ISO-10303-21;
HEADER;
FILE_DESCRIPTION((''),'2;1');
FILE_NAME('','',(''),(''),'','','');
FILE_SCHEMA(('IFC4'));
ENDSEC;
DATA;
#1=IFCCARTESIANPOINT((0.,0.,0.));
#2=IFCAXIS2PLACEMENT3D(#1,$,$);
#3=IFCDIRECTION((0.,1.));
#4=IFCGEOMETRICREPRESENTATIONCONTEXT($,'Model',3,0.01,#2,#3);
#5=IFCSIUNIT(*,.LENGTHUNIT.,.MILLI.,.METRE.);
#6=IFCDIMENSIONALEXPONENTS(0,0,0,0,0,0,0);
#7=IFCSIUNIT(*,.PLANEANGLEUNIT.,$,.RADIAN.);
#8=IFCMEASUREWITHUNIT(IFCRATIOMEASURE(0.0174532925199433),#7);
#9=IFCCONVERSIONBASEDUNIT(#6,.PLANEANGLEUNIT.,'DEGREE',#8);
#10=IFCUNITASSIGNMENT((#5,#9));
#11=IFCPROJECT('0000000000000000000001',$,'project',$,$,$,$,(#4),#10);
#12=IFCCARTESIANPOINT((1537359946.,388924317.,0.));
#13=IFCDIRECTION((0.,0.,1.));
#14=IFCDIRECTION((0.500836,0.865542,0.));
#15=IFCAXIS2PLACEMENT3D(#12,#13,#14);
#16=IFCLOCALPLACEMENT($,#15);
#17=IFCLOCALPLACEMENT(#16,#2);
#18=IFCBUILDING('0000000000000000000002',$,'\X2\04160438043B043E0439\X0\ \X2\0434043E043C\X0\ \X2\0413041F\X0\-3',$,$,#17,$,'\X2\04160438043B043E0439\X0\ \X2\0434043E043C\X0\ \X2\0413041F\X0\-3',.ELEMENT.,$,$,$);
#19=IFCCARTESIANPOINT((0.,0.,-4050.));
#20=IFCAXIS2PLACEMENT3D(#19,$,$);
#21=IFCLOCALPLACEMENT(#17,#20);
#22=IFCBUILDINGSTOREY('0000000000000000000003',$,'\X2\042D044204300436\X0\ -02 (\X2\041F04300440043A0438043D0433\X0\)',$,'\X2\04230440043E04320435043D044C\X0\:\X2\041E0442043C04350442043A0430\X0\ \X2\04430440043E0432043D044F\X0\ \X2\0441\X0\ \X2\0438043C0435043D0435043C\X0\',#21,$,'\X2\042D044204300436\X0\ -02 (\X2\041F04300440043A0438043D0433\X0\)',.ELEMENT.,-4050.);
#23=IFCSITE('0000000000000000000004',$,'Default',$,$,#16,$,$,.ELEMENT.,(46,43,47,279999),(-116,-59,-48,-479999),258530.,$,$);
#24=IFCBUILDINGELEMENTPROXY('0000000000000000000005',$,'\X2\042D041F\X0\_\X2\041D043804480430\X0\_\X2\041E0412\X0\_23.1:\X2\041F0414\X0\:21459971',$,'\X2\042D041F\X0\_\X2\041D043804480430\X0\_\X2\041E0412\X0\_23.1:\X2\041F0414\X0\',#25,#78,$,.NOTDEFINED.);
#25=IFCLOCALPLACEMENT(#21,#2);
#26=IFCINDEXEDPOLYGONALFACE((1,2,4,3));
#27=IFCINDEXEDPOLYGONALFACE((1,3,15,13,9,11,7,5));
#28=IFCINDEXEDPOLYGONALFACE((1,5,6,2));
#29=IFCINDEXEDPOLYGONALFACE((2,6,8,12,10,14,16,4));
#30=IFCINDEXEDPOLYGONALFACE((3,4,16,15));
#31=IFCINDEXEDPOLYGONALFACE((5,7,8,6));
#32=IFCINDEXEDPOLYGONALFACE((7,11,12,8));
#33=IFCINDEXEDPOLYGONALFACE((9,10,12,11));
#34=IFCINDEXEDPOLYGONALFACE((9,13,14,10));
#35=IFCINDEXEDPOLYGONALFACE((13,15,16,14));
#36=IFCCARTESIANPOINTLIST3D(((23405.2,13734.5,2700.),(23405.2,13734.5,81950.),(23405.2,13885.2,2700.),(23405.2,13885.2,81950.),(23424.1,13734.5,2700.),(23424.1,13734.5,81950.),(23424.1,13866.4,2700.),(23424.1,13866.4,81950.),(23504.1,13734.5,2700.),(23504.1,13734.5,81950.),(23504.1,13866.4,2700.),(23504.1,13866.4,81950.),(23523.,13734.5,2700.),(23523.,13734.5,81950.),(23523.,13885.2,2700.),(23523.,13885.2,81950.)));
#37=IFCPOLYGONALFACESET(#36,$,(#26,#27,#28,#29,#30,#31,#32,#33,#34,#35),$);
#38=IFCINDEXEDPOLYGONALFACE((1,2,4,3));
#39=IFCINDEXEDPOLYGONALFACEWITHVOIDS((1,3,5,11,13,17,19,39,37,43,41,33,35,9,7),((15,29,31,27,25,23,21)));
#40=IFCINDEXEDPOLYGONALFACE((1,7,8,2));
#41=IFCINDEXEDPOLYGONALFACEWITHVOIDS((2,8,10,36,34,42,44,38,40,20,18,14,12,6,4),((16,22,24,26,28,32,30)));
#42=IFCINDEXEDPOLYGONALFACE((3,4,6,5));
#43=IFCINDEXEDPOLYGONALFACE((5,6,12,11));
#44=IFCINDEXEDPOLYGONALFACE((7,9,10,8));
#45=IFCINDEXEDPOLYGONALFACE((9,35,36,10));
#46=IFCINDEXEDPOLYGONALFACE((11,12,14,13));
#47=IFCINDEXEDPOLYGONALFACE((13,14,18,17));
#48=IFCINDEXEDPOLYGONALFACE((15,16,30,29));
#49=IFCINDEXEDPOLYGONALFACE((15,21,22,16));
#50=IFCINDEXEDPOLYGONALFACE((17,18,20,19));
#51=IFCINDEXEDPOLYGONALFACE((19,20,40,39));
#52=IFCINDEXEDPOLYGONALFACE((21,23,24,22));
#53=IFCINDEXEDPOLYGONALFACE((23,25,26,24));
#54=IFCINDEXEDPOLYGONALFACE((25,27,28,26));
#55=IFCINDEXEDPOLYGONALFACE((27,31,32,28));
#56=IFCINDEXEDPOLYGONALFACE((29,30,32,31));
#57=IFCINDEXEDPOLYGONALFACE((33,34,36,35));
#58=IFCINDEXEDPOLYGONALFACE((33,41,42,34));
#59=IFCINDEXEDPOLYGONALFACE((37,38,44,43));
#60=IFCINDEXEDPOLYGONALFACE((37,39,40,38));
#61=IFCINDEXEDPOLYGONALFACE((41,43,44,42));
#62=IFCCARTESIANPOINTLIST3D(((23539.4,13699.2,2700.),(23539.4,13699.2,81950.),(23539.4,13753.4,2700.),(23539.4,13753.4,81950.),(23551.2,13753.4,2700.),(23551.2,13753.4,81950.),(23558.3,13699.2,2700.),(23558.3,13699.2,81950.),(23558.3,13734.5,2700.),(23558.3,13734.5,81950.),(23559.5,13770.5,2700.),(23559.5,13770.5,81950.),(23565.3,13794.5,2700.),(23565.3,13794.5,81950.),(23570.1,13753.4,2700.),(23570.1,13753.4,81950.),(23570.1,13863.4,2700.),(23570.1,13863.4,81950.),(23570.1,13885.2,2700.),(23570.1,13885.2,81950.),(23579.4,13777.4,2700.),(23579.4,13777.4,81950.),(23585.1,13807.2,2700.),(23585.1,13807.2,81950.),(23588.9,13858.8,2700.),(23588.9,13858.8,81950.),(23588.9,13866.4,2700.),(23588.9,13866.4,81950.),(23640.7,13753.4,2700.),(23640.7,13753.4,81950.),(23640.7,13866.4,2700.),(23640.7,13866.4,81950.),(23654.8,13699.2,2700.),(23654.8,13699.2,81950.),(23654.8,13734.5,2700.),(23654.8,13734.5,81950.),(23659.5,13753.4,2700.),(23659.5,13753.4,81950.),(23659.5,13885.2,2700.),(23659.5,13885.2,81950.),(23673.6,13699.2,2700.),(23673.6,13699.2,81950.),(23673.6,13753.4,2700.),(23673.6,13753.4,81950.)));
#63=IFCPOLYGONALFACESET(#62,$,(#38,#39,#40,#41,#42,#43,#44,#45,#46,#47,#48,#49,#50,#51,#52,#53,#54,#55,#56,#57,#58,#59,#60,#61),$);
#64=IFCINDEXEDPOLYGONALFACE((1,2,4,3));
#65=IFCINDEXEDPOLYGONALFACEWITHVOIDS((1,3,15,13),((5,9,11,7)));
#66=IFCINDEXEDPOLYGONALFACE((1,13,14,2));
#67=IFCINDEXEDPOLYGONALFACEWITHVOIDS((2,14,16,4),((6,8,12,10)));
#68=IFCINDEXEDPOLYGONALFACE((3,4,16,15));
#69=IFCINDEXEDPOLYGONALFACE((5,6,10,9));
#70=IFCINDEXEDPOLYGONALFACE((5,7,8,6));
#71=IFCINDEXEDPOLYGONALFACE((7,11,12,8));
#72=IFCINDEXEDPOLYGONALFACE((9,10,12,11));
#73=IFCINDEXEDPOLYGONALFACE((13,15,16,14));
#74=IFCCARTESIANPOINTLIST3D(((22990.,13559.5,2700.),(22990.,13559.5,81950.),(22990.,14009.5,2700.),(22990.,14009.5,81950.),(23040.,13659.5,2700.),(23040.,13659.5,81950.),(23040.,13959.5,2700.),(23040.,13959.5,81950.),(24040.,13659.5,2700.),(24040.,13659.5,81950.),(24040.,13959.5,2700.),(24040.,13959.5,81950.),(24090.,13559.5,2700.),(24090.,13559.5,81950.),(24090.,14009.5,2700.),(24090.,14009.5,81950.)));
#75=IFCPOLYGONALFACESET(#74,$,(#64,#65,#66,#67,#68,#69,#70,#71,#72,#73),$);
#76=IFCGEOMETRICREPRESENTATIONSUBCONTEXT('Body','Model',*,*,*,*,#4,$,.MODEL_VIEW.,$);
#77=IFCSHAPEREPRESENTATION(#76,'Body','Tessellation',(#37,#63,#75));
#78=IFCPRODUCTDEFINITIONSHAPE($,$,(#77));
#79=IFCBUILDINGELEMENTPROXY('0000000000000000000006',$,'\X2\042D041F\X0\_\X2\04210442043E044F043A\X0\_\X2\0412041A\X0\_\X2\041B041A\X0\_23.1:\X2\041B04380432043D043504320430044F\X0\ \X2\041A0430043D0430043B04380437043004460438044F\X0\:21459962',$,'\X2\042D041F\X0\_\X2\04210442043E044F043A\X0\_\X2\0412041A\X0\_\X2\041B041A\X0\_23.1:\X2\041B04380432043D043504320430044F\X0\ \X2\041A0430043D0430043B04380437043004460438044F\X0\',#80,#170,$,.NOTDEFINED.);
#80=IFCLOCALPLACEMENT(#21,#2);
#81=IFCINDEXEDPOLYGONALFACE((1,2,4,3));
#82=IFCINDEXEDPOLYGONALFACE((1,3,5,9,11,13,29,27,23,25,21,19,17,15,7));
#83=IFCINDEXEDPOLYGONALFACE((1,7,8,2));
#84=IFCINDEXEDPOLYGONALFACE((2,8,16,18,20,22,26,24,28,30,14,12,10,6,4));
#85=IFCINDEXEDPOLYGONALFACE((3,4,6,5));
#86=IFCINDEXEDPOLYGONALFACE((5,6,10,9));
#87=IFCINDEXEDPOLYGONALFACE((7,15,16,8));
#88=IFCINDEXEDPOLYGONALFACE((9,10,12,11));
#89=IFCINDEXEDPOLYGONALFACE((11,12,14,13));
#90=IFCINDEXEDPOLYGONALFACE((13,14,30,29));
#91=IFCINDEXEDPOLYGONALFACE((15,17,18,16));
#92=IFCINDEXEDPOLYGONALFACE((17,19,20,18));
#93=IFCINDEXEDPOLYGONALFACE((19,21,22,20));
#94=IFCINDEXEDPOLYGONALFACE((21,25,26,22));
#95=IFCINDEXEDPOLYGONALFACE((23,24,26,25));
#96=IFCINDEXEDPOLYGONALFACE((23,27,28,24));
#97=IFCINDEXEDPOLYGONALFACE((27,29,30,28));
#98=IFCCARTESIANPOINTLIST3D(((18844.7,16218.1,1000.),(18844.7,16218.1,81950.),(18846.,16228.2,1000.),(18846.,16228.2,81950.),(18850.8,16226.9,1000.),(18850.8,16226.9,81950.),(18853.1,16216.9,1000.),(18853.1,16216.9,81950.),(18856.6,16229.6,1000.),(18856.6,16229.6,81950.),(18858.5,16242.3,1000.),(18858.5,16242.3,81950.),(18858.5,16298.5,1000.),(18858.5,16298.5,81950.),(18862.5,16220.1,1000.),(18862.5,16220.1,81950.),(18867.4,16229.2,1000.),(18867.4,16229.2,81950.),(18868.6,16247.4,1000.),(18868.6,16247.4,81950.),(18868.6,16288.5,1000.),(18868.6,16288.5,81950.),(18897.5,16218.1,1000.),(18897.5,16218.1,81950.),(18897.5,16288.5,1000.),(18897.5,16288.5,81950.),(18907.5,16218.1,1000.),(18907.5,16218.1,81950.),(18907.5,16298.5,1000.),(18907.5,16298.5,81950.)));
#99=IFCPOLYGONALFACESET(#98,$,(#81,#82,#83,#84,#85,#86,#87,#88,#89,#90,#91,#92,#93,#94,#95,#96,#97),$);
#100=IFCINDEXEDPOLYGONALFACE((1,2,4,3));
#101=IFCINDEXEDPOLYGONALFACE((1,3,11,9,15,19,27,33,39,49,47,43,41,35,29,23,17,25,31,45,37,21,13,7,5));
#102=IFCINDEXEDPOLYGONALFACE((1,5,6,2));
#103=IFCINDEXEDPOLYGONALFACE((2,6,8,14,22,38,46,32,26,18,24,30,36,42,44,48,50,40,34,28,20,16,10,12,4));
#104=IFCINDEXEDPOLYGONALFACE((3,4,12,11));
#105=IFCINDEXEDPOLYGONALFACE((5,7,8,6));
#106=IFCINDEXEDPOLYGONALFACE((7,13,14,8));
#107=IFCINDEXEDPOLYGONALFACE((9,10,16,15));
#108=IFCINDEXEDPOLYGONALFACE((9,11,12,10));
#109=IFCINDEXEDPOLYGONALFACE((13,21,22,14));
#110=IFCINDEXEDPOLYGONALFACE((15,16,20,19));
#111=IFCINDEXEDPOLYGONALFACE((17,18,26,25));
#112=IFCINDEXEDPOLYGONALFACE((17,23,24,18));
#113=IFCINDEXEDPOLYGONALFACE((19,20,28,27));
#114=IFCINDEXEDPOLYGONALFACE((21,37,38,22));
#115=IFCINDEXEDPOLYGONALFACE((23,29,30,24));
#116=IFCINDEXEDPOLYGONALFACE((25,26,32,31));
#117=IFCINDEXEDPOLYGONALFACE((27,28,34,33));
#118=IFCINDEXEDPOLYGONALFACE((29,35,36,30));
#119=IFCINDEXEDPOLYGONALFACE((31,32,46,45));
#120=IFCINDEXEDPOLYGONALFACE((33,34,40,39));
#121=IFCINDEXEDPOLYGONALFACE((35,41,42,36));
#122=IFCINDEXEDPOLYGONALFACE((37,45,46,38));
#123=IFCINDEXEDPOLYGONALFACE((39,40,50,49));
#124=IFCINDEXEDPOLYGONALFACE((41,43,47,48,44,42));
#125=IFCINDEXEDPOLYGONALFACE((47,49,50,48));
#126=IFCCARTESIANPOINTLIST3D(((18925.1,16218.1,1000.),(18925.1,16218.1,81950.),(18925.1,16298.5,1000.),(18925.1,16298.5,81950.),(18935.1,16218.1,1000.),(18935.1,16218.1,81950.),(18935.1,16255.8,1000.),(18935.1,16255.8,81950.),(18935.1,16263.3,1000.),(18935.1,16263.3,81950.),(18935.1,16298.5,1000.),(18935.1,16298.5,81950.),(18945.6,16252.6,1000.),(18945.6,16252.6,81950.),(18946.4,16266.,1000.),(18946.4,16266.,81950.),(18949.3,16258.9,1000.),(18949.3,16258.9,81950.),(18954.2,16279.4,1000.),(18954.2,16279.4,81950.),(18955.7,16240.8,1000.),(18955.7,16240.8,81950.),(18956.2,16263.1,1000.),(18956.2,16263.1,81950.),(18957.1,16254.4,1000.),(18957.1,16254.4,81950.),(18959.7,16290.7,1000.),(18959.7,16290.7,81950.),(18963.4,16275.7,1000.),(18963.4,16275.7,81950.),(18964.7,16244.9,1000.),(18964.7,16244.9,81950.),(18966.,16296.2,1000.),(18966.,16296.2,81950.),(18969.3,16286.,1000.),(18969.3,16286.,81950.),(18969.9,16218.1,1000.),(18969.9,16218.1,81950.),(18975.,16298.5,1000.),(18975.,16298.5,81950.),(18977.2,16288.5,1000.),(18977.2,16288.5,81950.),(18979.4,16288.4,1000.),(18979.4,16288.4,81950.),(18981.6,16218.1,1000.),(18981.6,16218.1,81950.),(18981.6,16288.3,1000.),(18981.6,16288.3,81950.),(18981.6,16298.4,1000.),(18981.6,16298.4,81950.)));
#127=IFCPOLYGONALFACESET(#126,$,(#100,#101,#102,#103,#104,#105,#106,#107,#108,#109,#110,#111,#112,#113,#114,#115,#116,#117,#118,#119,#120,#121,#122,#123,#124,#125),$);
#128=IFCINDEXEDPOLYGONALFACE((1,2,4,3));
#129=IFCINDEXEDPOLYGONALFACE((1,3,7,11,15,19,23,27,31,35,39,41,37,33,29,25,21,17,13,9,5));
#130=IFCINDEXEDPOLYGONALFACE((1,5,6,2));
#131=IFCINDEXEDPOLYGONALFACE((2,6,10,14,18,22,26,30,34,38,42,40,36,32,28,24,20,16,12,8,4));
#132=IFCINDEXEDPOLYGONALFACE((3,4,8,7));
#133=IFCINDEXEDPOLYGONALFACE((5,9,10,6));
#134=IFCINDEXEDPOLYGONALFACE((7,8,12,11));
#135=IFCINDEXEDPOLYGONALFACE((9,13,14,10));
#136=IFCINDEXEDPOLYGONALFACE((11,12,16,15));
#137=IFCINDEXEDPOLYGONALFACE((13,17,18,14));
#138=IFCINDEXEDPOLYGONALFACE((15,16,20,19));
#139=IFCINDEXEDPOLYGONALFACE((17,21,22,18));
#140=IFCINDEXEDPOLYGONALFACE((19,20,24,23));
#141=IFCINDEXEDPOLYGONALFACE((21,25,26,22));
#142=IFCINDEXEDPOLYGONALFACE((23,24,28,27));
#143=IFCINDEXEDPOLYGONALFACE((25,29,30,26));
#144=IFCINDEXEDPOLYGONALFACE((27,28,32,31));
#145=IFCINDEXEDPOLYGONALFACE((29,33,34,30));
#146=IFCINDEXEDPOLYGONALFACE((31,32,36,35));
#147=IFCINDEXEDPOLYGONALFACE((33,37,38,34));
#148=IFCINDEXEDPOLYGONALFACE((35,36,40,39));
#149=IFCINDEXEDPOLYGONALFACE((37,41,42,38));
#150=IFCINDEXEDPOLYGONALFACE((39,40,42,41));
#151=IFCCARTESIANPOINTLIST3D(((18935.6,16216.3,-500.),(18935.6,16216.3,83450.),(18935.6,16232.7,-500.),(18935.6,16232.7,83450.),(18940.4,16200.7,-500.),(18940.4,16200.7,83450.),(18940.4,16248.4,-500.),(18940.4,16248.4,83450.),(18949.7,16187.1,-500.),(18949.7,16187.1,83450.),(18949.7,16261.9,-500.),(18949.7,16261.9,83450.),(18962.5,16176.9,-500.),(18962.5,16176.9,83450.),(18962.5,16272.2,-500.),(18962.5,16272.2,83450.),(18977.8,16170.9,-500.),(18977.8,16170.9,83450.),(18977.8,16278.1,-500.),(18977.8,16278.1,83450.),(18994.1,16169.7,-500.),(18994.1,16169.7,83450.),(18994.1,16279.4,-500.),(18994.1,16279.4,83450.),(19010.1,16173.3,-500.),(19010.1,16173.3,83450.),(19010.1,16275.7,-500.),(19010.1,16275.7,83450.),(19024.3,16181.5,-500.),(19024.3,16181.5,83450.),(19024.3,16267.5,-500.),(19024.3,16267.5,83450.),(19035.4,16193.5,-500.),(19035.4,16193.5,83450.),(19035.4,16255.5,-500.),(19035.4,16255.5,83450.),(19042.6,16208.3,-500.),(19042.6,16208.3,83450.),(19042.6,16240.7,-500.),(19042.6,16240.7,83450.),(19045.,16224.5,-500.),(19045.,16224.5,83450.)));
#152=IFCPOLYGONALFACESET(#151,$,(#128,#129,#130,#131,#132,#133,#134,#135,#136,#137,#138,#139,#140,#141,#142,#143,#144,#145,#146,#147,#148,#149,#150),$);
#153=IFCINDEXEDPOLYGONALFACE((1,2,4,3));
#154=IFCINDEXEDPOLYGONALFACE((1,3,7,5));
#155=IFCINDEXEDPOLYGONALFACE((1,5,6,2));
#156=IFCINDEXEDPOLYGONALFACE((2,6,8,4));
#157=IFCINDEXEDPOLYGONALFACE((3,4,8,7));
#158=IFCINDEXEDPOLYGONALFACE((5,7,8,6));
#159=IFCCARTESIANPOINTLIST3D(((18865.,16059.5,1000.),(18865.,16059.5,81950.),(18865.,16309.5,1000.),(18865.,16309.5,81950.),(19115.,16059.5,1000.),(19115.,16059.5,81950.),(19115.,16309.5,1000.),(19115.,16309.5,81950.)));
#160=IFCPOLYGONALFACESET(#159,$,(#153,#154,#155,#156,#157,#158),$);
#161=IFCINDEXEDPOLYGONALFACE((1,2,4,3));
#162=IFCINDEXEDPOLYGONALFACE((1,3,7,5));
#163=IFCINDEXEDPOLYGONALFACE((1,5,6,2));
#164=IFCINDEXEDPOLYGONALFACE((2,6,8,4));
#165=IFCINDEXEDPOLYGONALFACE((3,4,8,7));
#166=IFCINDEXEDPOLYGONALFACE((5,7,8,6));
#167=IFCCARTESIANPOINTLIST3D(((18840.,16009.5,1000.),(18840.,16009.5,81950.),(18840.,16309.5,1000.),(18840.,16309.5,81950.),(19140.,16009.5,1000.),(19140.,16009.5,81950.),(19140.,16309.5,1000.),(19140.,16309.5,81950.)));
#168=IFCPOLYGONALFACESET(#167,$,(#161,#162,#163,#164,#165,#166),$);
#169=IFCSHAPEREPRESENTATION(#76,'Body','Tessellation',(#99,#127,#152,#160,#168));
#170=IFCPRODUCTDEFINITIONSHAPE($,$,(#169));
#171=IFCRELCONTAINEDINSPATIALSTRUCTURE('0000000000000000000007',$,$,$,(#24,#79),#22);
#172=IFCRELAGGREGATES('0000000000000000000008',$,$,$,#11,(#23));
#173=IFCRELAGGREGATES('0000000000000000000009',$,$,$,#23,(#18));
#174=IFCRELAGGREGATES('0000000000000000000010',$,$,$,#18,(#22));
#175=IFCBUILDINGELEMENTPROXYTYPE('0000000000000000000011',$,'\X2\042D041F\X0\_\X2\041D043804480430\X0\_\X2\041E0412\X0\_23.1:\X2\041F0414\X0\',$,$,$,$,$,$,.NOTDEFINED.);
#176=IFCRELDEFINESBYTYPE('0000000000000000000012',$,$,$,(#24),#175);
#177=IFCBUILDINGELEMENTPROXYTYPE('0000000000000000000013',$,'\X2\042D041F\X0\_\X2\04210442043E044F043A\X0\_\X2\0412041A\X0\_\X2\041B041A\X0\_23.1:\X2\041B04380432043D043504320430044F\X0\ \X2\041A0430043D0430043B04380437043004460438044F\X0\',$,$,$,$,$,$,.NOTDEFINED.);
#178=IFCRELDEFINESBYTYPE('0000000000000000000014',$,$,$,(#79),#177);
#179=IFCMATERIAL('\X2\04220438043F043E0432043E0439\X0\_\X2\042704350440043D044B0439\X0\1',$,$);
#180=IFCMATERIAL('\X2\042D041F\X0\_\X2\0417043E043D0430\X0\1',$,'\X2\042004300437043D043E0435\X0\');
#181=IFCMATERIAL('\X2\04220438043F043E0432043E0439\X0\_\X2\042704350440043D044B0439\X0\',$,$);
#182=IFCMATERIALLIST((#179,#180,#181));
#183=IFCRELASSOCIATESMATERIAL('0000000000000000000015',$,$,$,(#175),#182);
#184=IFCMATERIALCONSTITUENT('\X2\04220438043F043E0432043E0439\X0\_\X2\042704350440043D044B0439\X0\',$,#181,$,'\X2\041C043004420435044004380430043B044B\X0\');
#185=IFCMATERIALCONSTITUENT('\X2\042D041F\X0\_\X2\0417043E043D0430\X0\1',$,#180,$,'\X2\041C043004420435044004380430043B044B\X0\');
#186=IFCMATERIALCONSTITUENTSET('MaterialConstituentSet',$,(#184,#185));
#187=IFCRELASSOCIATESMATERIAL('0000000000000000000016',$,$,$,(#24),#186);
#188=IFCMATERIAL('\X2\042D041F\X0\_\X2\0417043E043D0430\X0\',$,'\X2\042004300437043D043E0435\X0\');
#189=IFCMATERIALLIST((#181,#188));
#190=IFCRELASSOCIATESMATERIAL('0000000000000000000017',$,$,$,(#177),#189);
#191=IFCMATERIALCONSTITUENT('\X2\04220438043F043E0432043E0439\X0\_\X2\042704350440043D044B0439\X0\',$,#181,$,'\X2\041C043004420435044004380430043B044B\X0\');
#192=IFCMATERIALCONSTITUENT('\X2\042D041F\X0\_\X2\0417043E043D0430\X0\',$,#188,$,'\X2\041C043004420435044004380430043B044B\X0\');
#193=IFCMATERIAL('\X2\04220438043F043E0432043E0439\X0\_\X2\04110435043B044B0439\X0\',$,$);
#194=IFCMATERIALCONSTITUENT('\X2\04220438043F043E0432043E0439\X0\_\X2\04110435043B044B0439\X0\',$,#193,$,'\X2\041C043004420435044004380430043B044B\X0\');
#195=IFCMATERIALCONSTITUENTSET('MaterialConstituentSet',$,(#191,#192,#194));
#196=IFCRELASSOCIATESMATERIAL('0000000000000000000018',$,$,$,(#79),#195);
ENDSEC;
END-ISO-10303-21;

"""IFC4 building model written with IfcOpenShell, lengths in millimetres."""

from ifc_helpers import new_model, entity, si_unit, converted_unit, direction, frame, frame_2d, origin, place, context, subcontext, project, spatial, polyline, rectangle, circle, outline, extrude, source, transform, mapped, material, material_list, constituent, constituent_set, type_object, type_shapes, element, save


model = new_model("IFC4")

# Units and contexts
model_context = context("Model", 3, precision=0.01, world=origin(), true_north=direction((0.0, 1.0)))
body_context = subcontext(model_context, "Body", "Model", "MODEL_VIEW")
ifc_project = project(units=[si_unit("LENGTHUNIT", "METRE", prefix="MILLI"), converted_unit("PLANEANGLEUNIT", "DEGREE", entity("IfcRatioMeasure", 0.0174532925199433), si_unit("PLANEANGLEUNIT", "RADIAN"), dimensions=[0, 0, 0, 0, 0, 0, 0])], contexts=[model_context])

# Site, building, storey
site_placement = place(None, frame((1537359946.0, 388924317.0, 0.0), z_axis=(0.0, 0.0, 1.0), x_axis=(0.500836, 0.865542, 0.0)))
site = spatial("IfcSite", under=ifc_project, at=site_placement, Name="Default", CompositionType="ELEMENT", RefLatitude=(46, 43, 47, 279999), RefLongitude=(-116, -59, -48, -479999), RefElevation=258530.0)
building_placement = place(site_placement, origin())
building = spatial("IfcBuilding", under=site, at=building_placement, Name="Жилой дом ГП-3", LongName="Жилой дом ГП-3", CompositionType="ELEMENT")
storey_placement = place(building_placement, frame((0.0, 0.0, -4050.0)))
storey = spatial("IfcBuildingStorey", under=building, at=storey_placement, Name="Этаж -02 (Паркинг)", ObjectType="Уровень:Отметка уровня с именем", LongName="Этаж -02 (Паркинг)", CompositionType="ELEMENT", Elevation=-4050.0)

# Building element proxies
ifc_material_1 = material(Name="Типовой_Черный")
ifc_material_2 = material(Name="ЭП_Зона", Category="Разное")
ifc_material_3 = material(Name="Типовой_Белый")
ifc_material_4 = material(Name="ЭП_Зона1", Category="Разное")
ifc_material_5 = material(Name="Типовой_Черный1")
ifc_material_list_1 = material_list([ifc_material_5, ifc_material_4, ifc_material_1])
building_element_proxy_type_1 = type_object("IfcBuildingElementProxyType", Name="ЭП_Ниша_ОВ_23.1:ПД", PredefinedType="NOTDEFINED", material=ifc_material_list_1)
shared_shape_1 = source(origin(), body_context, "Body", "SweptSolid", [
    extrude(outline(polyline([(-80.1, -58.9), (70.6, -58.9), (70.6, -40.0), (-61.2, -40.0), (-61.2, 40.0), (70.6, 40.0), (70.6, 58.9), (-80.1, 58.9), (-80.1, -58.9)])), frame((474.1, 245.6, 0.0), z_axis=(0.0, 0.0, 1.0), x_axis=(0.0, -1.0, 0.0)), (0.0, 0.0, 1.0), 79250.0),
    extrude(outline(polyline([(-120.0, 29.1), (-120.0, -60.4), (11.8, -60.4), (11.8, -74.5), (66.0, -74.5), (66.0, -55.6), (30.7, -55.6), (30.7, 40.9), (66.0, 40.9), (66.0, 59.7), (11.8, 59.7), (11.8, 48.0), (-5.2, 39.7), (-29.3, 33.8), (-98.2, 29.1), (-120.0, 29.1)]), holes=[polyline([(-101.2, -41.5), (-101.2, 10.3), (-93.6, 10.3), (-42.0, 14.1), (-12.2, 19.8), (11.8, 29.1), (11.8, -41.5), (-101.2, -41.5)])]), frame((609.2, 205.7, 0.0), z_axis=(0.0, 0.0, -1.0), x_axis=(0.0, -1.0, 0.0)), (0.0, 0.0, -1.0), 79250.0),
    extrude(outline(polyline([(-550.0, -225.0), (550.0, -225.0), (550.0, 225.0), (-550.0, 225.0), (-550.0, -225.0)]), holes=[polyline([(500.0, 175.0), (500.0, -125.0), (-500.0, -125.0), (-500.0, 175.0), (500.0, 175.0)])]), frame((550.0, 225.0, 0.0)), (0.0, 0.0, 1.0), 79250.0),
])
type_shapes(building_element_proxy_type_1, [shared_shape_1])
ifc_constituent_1 = constituent(ifc_material_1, Name="Типовой_Черный", Category="Материалы")
ifc_constituent_2 = constituent(ifc_material_4, Name="ЭП_Зона1", Category="Материалы")
ifc_constituent_set_1 = constituent_set(constituents=[ifc_constituent_1, ifc_constituent_2], Name="MaterialConstituentSet")
proxy_1_placement = place(storey_placement, frame((22990.0, 13559.5, 2700.0)))
element("IfcBuildingElementProxy", 1, at=proxy_1_placement, inside=storey, type_object=building_element_proxy_type_1, material=ifc_constituent_set_1, Name="ЭП_Ниша_ОВ_23.1:ПД:21459971", ObjectType="ЭП_Ниша_ОВ_23.1:ПД", PredefinedType="NOTDEFINED", context=body_context, shape_type="MappedRepresentation", body=[
    mapped(shared_shape_1, transform((0.0, 0.0, 0.0), scale=1.0)),
])
ifc_constituent_3 = constituent(ifc_material_1, Name="Типовой_Черный", Category="Материалы")
ifc_constituent_4 = constituent(ifc_material_2, Name="ЭП_Зона", Category="Материалы")
ifc_constituent_5 = constituent(ifc_material_3, Name="Типовой_Белый", Category="Материалы")
ifc_constituent_set_2 = constituent_set(constituents=[ifc_constituent_3, ifc_constituent_4, ifc_constituent_5], Name="MaterialConstituentSet")
ifc_material_list_2 = material_list([ifc_material_1, ifc_material_2])
building_element_proxy_type_2 = type_object("IfcBuildingElementProxyType", Name="ЭП_Стояк_ВК_ЛК_23.1:Ливневая Канализация", PredefinedType="NOTDEFINED", material=ifc_material_list_2)
shared_shape_2 = source(origin(), body_context, "Body", "SweptSolid", [
    extrude(outline(polyline([(-53.9, 11.1), (-53.9, -37.8), (26.5, -37.8), (26.5, -27.8), (-43.9, -27.8), (-43.9, 1.1), (-2.9, 1.1), (15.4, 2.3), (24.5, 7.2), (27.7, 16.6), (26.5, 25.0), (16.4, 23.7), (17.7, 18.9), (15.0, 13.1), (2.3, 11.1), (-53.9, 11.1)])), frame((29.7, -64.9, -3050.0), z_axis=(0.0, 0.0, -1.0), x_axis=(0.0, -1.0, 0.0)), (0.0, 0.0, -1.0), 80950.0),
    extrude(outline(polyline([(-32.1, -31.9), (48.3, -31.9), (48.3, -21.8), (10.6, -21.8), (13.8, -11.4), (25.6, -1.3), (48.3, 13.0), (48.3, 24.6), (21.4, 7.7), (12.0, 0.1), (7.4, -7.7), (3.3, -0.7), (-9.3, 6.4), (-19.7, 12.3), (-22.1, 20.2), (-22.0, 22.4), (-22.0, 24.6), (-32.0, 24.6), (-32.1, 18.0), (-29.9, 9.0), (-24.3, 2.8), (-13.1, -2.8), (0.4, -10.6), (3.0, -21.8), (-32.1, -21.8), (-32.1, -31.9)])), frame((117.0, -43.1, -3050.0), z_axis=(0.0, 0.0, 1.0), x_axis=(0.0, -1.0, 0.0)), (0.0, 0.0, 1.0), 80950.0),
    extrude(circle(Radius=55.0, at=frame_2d((0.0, 0.0), x_axis=(1.0, 0.0))), frame((150.0, -85.0, -4550.0)), (0.0, 0.0, 1.0), 83950.0),
    extrude(rectangle(XDim=250.0, YDim=250.0, at=frame_2d((0.0, 0.0), x_axis=(1.0, 0.0))), frame((150.0, -125.0, -3050.0)), (0.0, 0.0, 1.0), 80950.0),
    extrude(rectangle(XDim=300.0, YDim=300.0, at=frame_2d((0.0, 0.0), x_axis=(1.0, 0.0))), frame((150.0, -150.0, -3050.0)), (0.0, 0.0, 1.0), 80950.0),
])
type_shapes(building_element_proxy_type_2, [shared_shape_2])
proxy_2_placement = place(storey_placement, frame((18840.0, 16309.5, 4050.0)))
element("IfcBuildingElementProxy", 2, at=proxy_2_placement, inside=storey, type_object=building_element_proxy_type_2, material=ifc_constituent_set_2, Name="ЭП_Стояк_ВК_ЛК_23.1:Ливневая Канализация:21459962", ObjectType="ЭП_Стояк_ВК_ЛК_23.1:Ливневая Канализация", PredefinedType="NOTDEFINED", context=body_context, shape_type="MappedRepresentation", body=[
    mapped(shared_shape_2, transform((0.0, 0.0, 0.0), scale=1.0)),
])

save(model, "model.ifc")
